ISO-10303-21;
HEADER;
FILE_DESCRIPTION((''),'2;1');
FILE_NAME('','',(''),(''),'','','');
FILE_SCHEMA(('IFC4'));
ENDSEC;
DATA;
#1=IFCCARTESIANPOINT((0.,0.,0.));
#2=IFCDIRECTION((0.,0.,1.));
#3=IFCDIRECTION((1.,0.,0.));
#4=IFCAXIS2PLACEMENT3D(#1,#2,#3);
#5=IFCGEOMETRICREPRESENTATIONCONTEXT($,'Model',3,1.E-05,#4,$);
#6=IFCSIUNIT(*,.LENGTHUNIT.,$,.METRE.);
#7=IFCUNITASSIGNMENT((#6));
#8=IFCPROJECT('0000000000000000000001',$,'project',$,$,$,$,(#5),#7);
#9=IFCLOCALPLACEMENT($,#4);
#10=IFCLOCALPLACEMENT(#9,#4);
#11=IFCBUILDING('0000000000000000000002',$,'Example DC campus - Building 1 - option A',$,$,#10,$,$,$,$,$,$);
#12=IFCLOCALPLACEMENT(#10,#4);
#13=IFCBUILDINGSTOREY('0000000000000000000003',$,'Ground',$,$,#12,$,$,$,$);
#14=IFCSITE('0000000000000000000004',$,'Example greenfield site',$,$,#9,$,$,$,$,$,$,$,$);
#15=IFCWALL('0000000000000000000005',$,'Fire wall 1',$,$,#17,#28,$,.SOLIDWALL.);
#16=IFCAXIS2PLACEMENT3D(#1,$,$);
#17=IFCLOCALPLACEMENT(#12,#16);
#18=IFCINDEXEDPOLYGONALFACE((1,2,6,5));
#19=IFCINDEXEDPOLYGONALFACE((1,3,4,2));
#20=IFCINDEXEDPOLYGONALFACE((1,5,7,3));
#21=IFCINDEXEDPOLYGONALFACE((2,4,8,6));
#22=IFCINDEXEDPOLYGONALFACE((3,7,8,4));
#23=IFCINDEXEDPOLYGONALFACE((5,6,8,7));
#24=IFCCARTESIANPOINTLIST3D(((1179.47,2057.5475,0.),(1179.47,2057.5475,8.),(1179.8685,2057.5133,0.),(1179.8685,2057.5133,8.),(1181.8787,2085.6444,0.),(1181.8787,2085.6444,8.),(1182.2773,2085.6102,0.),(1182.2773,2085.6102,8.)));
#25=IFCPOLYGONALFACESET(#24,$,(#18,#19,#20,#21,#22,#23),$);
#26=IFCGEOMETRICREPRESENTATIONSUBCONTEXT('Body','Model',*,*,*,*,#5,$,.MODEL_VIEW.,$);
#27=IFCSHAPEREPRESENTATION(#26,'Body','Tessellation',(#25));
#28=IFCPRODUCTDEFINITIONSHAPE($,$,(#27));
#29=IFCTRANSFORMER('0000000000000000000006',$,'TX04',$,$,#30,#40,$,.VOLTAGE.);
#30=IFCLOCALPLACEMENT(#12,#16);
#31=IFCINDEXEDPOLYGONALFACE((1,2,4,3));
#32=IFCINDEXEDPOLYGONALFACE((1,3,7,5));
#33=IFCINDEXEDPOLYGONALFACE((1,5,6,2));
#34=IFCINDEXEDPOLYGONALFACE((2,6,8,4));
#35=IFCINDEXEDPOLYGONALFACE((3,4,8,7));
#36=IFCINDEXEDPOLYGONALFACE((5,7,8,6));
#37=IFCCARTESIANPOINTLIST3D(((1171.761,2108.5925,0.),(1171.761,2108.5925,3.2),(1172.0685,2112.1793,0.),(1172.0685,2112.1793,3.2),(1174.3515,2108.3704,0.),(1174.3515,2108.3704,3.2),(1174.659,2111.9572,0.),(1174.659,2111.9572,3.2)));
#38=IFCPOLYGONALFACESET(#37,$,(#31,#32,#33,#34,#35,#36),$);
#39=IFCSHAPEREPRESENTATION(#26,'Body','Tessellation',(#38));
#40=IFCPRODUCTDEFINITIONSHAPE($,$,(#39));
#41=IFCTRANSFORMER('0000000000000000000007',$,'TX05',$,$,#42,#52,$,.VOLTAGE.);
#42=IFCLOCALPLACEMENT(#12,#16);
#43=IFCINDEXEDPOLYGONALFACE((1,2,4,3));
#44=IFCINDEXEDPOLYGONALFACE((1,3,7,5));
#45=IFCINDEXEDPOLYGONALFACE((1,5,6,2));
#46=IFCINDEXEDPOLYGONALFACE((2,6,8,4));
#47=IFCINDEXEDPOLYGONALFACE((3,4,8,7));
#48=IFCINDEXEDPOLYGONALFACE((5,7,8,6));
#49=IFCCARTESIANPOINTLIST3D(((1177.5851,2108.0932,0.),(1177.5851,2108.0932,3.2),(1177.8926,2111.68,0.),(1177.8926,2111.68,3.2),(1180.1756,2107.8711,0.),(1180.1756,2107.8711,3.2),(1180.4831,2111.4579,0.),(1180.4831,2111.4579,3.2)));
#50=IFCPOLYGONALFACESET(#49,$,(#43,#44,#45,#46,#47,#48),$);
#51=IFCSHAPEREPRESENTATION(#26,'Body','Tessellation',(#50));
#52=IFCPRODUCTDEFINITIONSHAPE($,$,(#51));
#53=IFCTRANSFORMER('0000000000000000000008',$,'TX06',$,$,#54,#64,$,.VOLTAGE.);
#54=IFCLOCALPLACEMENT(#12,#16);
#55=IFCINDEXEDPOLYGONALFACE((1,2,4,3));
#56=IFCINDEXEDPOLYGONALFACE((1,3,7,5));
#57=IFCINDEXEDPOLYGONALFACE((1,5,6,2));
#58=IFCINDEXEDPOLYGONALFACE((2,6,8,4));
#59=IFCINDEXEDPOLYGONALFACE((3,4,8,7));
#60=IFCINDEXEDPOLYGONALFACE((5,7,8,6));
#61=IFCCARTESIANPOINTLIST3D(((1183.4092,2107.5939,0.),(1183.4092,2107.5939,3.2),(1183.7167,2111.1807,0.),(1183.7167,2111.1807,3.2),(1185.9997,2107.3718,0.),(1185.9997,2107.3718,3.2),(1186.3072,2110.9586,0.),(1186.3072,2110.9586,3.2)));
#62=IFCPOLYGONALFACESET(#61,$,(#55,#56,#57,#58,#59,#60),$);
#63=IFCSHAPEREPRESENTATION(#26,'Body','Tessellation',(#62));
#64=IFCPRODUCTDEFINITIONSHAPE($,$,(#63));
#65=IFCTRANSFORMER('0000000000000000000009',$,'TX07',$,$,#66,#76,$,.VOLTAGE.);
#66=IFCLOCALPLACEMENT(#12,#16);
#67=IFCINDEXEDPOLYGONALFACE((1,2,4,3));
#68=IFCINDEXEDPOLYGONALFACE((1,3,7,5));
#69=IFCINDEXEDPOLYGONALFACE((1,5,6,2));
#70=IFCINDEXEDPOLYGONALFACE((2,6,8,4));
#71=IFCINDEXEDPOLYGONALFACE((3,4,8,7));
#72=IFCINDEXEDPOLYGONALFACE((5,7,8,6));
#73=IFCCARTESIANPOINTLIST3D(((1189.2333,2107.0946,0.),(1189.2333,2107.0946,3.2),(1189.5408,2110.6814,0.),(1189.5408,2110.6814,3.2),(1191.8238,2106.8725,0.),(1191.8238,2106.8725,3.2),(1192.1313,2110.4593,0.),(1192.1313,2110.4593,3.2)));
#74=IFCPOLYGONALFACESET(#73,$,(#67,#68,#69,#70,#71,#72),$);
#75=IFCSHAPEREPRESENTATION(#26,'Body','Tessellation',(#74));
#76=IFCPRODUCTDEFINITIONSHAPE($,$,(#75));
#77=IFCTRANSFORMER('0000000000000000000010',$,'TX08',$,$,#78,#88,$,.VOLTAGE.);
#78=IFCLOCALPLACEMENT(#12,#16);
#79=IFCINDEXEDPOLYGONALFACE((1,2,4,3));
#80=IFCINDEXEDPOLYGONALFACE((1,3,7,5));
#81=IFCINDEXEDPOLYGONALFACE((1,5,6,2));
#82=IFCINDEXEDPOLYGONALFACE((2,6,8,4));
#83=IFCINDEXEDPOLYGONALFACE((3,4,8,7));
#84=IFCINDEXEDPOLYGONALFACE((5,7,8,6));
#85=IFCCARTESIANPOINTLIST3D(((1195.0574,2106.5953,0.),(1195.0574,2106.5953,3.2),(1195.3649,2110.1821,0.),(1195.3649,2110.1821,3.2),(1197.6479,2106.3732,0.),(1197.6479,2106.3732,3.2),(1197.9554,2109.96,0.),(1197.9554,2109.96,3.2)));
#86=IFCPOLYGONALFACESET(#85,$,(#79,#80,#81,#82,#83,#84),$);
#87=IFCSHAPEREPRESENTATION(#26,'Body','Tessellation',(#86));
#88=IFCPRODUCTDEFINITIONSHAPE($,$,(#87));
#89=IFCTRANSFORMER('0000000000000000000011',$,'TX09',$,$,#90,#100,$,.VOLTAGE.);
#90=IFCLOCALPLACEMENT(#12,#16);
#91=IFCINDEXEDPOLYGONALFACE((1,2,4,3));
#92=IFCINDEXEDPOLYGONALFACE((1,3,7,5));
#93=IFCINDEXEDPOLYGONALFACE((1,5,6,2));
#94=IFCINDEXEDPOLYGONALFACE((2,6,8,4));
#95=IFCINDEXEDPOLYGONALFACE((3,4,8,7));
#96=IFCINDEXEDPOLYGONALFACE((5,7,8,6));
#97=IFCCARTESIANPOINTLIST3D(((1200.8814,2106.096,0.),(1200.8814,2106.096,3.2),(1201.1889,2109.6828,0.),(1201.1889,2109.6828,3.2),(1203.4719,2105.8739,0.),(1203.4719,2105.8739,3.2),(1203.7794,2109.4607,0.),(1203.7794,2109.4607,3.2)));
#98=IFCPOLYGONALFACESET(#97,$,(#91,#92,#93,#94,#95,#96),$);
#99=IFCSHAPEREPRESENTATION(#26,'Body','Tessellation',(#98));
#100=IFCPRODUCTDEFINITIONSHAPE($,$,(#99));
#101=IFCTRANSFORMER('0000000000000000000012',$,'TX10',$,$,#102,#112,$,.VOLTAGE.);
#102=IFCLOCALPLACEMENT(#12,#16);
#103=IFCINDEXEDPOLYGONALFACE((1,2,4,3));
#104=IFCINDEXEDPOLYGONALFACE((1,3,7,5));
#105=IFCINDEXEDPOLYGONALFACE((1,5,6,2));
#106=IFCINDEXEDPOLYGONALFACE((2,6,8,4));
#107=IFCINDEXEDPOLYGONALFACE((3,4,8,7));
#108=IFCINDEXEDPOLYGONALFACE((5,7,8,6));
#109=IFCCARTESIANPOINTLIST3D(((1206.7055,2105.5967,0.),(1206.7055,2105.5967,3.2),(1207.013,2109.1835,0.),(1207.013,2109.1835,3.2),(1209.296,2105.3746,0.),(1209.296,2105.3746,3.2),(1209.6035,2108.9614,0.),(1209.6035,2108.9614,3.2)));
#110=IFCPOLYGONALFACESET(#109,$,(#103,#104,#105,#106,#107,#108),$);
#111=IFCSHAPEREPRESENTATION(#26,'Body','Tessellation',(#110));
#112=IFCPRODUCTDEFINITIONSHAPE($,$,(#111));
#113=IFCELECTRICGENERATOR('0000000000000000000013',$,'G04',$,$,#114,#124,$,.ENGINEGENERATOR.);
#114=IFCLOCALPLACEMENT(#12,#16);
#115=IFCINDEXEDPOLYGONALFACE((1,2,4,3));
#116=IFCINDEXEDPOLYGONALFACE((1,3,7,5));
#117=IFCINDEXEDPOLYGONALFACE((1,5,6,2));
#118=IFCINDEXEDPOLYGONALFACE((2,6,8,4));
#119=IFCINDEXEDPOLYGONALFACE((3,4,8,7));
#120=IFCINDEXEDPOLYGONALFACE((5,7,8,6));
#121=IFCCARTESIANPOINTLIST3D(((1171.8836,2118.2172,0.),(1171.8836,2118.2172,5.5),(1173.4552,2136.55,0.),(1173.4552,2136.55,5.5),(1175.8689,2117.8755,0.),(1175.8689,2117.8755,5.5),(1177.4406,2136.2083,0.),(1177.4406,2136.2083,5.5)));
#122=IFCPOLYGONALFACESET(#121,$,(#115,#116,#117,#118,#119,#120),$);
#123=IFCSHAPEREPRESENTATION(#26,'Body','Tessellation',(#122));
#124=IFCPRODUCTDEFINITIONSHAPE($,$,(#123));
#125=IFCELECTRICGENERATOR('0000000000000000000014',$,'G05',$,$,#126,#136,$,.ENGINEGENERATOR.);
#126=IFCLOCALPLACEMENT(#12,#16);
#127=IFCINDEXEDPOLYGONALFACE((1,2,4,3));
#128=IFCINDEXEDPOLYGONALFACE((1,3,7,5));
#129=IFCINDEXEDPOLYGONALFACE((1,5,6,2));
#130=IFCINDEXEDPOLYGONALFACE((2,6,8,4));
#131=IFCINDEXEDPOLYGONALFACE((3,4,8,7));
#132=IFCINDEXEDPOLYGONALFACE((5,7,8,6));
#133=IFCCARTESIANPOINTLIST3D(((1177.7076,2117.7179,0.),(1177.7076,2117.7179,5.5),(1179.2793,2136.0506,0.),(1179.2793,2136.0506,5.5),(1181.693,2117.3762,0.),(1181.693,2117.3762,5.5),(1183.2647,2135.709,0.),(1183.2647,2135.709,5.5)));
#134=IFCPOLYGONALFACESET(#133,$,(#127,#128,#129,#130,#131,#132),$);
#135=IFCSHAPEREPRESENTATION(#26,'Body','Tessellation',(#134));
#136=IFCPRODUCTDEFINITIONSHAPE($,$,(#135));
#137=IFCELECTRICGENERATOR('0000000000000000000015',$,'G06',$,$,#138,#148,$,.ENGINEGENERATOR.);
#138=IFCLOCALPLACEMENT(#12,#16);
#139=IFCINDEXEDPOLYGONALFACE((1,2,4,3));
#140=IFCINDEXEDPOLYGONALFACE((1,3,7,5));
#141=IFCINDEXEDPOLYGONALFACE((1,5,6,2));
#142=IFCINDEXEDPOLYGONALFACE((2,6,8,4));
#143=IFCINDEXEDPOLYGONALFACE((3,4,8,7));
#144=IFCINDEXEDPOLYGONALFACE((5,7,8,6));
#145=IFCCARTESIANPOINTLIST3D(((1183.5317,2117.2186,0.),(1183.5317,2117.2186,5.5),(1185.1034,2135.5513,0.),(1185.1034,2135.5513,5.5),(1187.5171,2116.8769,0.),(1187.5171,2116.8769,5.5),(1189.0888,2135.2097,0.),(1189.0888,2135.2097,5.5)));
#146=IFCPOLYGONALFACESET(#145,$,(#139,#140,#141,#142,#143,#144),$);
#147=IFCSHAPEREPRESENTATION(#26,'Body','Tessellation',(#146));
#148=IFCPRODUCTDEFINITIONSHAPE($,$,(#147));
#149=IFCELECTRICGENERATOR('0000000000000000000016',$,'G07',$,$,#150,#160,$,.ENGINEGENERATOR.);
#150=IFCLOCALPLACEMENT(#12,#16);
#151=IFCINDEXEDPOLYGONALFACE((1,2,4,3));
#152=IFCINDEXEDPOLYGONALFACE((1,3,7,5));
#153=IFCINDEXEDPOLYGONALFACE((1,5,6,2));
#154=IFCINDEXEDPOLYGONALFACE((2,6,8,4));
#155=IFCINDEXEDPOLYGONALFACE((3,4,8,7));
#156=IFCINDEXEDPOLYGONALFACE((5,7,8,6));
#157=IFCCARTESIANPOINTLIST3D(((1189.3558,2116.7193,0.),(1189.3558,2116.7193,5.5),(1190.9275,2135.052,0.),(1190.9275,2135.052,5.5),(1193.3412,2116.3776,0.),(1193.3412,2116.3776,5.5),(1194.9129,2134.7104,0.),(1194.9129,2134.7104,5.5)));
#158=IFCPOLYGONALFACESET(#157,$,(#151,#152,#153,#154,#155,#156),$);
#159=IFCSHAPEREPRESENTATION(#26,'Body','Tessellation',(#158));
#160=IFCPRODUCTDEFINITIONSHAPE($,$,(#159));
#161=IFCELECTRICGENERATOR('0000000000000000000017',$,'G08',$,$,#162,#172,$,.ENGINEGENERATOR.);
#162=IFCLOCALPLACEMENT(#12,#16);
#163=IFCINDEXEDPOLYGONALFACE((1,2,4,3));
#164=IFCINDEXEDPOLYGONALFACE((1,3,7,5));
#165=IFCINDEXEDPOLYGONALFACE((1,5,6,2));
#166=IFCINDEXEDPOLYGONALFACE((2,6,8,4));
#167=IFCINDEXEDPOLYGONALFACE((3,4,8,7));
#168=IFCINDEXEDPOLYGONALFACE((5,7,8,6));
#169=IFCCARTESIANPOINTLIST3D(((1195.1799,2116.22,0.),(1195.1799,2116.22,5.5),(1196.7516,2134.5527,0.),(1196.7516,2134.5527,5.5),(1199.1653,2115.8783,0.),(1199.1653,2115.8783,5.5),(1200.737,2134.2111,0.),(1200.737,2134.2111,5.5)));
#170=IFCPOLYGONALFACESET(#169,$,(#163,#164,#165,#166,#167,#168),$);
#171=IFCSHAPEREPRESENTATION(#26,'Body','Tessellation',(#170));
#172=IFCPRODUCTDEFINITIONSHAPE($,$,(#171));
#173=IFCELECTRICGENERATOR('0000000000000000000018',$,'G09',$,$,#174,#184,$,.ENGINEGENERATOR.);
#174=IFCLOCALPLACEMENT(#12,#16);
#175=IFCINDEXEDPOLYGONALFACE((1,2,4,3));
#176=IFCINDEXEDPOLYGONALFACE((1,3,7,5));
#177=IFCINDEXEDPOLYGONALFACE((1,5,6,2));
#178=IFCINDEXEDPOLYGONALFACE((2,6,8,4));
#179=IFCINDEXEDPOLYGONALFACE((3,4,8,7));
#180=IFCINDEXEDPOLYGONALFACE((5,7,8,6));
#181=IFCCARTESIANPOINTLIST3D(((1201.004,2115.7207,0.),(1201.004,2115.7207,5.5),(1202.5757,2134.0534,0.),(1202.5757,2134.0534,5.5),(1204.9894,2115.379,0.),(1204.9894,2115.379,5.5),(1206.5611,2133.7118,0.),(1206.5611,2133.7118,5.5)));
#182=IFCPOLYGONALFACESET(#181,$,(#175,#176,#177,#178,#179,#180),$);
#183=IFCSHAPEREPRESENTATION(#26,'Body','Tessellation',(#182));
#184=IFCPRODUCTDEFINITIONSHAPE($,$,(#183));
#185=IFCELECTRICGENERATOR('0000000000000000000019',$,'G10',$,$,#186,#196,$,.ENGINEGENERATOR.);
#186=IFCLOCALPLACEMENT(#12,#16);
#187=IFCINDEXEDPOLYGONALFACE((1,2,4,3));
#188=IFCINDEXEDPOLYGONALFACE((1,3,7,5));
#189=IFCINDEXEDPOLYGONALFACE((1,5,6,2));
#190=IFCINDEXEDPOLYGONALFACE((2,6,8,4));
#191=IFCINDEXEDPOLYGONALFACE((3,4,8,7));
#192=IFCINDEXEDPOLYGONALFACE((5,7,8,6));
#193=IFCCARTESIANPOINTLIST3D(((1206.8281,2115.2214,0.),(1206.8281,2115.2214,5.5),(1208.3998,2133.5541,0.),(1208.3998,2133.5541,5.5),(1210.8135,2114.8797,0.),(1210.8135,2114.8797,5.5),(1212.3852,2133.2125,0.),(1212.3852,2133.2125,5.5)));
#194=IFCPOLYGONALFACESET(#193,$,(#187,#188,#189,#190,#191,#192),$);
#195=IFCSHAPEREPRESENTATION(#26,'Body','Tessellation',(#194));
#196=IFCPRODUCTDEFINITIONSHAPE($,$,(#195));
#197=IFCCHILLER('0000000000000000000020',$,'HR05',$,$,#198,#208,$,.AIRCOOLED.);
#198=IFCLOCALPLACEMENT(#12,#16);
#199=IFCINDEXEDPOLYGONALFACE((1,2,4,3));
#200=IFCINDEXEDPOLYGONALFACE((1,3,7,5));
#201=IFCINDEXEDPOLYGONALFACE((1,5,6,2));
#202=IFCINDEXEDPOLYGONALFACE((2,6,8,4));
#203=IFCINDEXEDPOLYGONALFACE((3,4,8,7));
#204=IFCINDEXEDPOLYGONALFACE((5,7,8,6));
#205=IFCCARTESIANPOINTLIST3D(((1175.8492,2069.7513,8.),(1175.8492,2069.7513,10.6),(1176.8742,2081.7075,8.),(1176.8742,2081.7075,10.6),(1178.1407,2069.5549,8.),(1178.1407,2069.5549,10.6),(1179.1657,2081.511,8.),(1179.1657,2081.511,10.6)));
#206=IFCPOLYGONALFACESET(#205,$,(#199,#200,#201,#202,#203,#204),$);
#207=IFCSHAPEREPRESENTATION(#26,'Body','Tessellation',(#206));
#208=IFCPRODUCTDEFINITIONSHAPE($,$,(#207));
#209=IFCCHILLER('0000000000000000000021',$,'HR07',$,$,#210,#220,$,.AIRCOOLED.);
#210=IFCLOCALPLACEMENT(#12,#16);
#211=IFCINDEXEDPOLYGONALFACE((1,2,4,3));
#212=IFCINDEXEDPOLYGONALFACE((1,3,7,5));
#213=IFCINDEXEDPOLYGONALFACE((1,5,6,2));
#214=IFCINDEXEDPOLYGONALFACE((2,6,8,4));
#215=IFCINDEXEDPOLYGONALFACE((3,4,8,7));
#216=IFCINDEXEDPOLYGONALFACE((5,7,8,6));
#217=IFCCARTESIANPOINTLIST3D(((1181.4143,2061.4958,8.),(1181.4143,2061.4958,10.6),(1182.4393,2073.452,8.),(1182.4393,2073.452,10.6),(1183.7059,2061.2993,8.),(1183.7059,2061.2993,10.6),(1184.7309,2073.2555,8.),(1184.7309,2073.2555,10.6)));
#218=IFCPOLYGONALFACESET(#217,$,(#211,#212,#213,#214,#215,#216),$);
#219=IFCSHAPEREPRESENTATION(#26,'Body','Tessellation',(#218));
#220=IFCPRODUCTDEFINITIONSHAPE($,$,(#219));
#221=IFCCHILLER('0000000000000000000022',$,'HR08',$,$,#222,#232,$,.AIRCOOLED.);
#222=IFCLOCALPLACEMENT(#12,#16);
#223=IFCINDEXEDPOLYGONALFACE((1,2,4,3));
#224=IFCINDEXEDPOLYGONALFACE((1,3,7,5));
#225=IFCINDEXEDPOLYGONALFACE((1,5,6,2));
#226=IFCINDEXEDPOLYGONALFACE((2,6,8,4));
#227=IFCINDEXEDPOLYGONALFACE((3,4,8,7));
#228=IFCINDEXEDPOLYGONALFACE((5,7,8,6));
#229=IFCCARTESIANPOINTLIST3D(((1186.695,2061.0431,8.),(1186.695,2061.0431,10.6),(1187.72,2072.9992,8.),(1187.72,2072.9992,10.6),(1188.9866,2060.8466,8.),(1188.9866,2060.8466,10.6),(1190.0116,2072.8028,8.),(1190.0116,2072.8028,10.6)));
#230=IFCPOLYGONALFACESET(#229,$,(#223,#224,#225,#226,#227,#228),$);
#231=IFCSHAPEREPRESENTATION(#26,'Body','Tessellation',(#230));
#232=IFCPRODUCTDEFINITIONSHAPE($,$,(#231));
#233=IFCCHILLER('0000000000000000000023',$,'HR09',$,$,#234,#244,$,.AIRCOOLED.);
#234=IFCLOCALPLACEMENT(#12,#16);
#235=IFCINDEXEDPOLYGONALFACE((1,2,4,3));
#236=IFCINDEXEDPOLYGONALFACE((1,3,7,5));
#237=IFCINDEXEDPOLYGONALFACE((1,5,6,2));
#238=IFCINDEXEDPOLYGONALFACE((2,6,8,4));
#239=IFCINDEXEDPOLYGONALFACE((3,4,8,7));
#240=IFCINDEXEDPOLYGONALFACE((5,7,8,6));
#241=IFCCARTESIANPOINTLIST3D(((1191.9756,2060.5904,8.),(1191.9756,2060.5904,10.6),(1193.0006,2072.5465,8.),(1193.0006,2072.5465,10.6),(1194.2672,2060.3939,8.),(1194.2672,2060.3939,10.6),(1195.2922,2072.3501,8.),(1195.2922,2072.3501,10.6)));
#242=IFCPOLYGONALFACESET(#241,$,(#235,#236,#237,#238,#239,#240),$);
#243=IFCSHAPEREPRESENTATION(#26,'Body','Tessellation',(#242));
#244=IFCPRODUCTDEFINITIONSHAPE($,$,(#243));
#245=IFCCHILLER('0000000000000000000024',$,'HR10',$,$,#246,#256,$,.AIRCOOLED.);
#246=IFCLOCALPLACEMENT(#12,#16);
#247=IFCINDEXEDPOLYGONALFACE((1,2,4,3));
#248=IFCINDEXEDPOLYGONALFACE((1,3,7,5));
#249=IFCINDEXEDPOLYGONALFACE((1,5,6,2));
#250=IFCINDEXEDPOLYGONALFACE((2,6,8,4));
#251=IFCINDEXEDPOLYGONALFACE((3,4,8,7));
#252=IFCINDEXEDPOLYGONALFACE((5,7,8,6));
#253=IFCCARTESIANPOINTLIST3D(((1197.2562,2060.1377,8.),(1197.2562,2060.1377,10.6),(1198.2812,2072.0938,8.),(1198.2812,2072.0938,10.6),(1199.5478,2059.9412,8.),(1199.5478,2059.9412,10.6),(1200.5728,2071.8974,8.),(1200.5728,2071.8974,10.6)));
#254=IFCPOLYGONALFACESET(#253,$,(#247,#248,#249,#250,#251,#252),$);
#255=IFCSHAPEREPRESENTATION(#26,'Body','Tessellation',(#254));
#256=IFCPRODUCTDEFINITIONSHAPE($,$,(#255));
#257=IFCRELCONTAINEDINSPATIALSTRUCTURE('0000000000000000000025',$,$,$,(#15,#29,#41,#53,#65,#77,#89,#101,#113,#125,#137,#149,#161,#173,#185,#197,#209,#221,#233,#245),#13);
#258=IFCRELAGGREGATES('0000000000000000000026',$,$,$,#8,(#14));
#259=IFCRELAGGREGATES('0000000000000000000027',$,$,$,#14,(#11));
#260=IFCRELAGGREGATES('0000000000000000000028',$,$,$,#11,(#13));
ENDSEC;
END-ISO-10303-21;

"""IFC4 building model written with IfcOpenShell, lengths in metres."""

from ifc_helpers import new_model, si_unit, frame, origin_with_axes, place, context, subcontext, project, spatial, line, indexed_curve, outline, extrude, element, save


model = new_model("IFC4")

# Units and contexts
model_context = context("Model", 3, precision=1e-05, world=origin_with_axes())
body_context = subcontext(model_context, "Body", "Model", "MODEL_VIEW")
ifc_project = project(units=[si_unit("LENGTHUNIT", "METRE")], contexts=[model_context])

# Site, building, storey
site_placement = place(None, origin_with_axes())
site = spatial("IfcSite", under=ifc_project, at=site_placement, Name="Example greenfield site")
building_placement = place(site_placement, origin_with_axes())
building = spatial("IfcBuilding", under=site, at=building_placement, Name="Example DC campus - Building 1 - option A")
storey_placement = place(building_placement, origin_with_axes())
storey = spatial("IfcBuildingStorey", under=building, at=storey_placement, Name="Ground")

# Wall
wall_placement = place(storey_placement, frame((1179.47, 2057.5475, 0.0), z_axis=(0.0, 0.0, 1.0), x_axis=(0.996345, -0.085417, 0.0)))
element("IfcWall", 1, at=wall_placement, inside=storey, Name="Fire wall 1", PredefinedType="SOLIDWALL", context=body_context, shape_type="SweptSolid", body=[
    extrude(outline(indexed_curve([(0.0, 0.0), (0.4, 0.0), (0.4, 28.2), (0.0, 28.2)], segments=[line(1, 2, 3, 4, 1)])), origin_with_axes(), (0.0, 0.0, 1.0), 8.0),
])

# Transformers
for number, where, z_axis, x_axis, name in (
    (2, (1171.761, 2108.5925, 0.0), (0.0, 0.0, 1.0), (0.996345, -0.085417, 0.0), "TX04"),
    (3, (1177.5851, 2108.0932, 0.0), (0.0, 0.0, 1.0), (0.996345, -0.085417, 0.0), "TX05"),
    (4, (1183.4092, 2107.5939, 0.0), (0.0, 0.0, 1.0), (0.996345, -0.085417, 0.0), "TX06"),
    (5, (1189.2333, 2107.0946, 0.0), (0.0, 0.0, 1.0), (0.996345, -0.085417, 0.0), "TX07"),
    (6, (1195.0574, 2106.5953, 0.0), (0.0, 0.0, 1.0), (0.996345, -0.085417, 0.0), "TX08"),
    (7, (1200.8814, 2106.096, 0.0), (0.0, 0.0, 1.0), (0.996345, -0.085417, 0.0), "TX09"),
    (8, (1206.7055, 2105.5967, 0.0), (0.0, 0.0, 1.0), (0.996345, -0.085417, 0.0), "TX10"),
):
    element("IfcTransformer", number, at=place(storey_placement, frame(where, z_axis=z_axis, x_axis=x_axis)), inside=storey, Name=name, PredefinedType="VOLTAGE", context=body_context, shape_type="SweptSolid", body=[
        extrude(outline(indexed_curve([(0.0, 0.0), (2.6, 0.0), (2.6, 3.6), (0.0, 3.6)], segments=[line(1, 2, 3, 4, 1)])), origin_with_axes(), (0.0, 0.0, 1.0), 3.2),
    ])

# Electric generators
for number, where, z_axis, x_axis, name in (
    (9, (1171.8836, 2118.2172, 0.0), (0.0, 0.0, 1.0), (0.996345, -0.085417, 0.0), "G04"),
    (10, (1177.7076, 2117.7179, 0.0), (0.0, 0.0, 1.0), (0.996345, -0.085417, 0.0), "G05"),
    (11, (1183.5317, 2117.2186, 0.0), (0.0, 0.0, 1.0), (0.996345, -0.085417, 0.0), "G06"),
    (12, (1189.3558, 2116.7193, 0.0), (0.0, 0.0, 1.0), (0.996345, -0.085417, 0.0), "G07"),
    (13, (1195.1799, 2116.22, 0.0), (0.0, 0.0, 1.0), (0.996345, -0.085417, 0.0), "G08"),
    (14, (1201.004, 2115.7207, 0.0), (0.0, 0.0, 1.0), (0.996345, -0.085417, 0.0), "G09"),
    (15, (1206.8281, 2115.2214, 0.0), (0.0, 0.0, 1.0), (0.996345, -0.085417, 0.0), "G10"),
):
    element("IfcElectricGenerator", number, at=place(storey_placement, frame(where, z_axis=z_axis, x_axis=x_axis)), inside=storey, Name=name, PredefinedType="ENGINEGENERATOR", context=body_context, shape_type="SweptSolid", body=[
        extrude(outline(indexed_curve([(0.0, 0.0), (4.0, 0.0), (4.0, 18.4), (0.0, 18.4)], segments=[line(1, 2, 3, 4, 1)])), origin_with_axes(), (0.0, 0.0, 1.0), 5.5),
    ])

# Chillers
for number, where, z_axis, x_axis, name in (
    (16, (1175.8492, 2069.7513, 8.0), (0.0, 0.0, 1.0), (0.996345, -0.085417, 0.0), "HR05"),
    (17, (1181.4143, 2061.4958, 8.0), (0.0, 0.0, 1.0), (0.996345, -0.085417, 0.0), "HR07"),
    (18, (1186.695, 2061.0431, 8.0), (0.0, 0.0, 1.0), (0.996345, -0.085417, 0.0), "HR08"),
    (19, (1191.9756, 2060.5904, 8.0), (0.0, 0.0, 1.0), (0.996345, -0.085417, 0.0), "HR09"),
    (20, (1197.2562, 2060.1377, 8.0), (0.0, 0.0, 1.0), (0.996345, -0.085417, 0.0), "HR10"),
):
    element("IfcChiller", number, at=place(storey_placement, frame(where, z_axis=z_axis, x_axis=x_axis)), inside=storey, Name=name, PredefinedType="AIRCOOLED", context=body_context, shape_type="SweptSolid", body=[
        extrude(outline(indexed_curve([(0.0, 0.0), (2.3, 0.0), (2.3, 12.0), (0.0, 12.0)], segments=[line(1, 2, 3, 4, 1)])), origin_with_axes(), (0.0, 0.0, 1.0), 2.6),
    ])

save(model, "model.ifc")
